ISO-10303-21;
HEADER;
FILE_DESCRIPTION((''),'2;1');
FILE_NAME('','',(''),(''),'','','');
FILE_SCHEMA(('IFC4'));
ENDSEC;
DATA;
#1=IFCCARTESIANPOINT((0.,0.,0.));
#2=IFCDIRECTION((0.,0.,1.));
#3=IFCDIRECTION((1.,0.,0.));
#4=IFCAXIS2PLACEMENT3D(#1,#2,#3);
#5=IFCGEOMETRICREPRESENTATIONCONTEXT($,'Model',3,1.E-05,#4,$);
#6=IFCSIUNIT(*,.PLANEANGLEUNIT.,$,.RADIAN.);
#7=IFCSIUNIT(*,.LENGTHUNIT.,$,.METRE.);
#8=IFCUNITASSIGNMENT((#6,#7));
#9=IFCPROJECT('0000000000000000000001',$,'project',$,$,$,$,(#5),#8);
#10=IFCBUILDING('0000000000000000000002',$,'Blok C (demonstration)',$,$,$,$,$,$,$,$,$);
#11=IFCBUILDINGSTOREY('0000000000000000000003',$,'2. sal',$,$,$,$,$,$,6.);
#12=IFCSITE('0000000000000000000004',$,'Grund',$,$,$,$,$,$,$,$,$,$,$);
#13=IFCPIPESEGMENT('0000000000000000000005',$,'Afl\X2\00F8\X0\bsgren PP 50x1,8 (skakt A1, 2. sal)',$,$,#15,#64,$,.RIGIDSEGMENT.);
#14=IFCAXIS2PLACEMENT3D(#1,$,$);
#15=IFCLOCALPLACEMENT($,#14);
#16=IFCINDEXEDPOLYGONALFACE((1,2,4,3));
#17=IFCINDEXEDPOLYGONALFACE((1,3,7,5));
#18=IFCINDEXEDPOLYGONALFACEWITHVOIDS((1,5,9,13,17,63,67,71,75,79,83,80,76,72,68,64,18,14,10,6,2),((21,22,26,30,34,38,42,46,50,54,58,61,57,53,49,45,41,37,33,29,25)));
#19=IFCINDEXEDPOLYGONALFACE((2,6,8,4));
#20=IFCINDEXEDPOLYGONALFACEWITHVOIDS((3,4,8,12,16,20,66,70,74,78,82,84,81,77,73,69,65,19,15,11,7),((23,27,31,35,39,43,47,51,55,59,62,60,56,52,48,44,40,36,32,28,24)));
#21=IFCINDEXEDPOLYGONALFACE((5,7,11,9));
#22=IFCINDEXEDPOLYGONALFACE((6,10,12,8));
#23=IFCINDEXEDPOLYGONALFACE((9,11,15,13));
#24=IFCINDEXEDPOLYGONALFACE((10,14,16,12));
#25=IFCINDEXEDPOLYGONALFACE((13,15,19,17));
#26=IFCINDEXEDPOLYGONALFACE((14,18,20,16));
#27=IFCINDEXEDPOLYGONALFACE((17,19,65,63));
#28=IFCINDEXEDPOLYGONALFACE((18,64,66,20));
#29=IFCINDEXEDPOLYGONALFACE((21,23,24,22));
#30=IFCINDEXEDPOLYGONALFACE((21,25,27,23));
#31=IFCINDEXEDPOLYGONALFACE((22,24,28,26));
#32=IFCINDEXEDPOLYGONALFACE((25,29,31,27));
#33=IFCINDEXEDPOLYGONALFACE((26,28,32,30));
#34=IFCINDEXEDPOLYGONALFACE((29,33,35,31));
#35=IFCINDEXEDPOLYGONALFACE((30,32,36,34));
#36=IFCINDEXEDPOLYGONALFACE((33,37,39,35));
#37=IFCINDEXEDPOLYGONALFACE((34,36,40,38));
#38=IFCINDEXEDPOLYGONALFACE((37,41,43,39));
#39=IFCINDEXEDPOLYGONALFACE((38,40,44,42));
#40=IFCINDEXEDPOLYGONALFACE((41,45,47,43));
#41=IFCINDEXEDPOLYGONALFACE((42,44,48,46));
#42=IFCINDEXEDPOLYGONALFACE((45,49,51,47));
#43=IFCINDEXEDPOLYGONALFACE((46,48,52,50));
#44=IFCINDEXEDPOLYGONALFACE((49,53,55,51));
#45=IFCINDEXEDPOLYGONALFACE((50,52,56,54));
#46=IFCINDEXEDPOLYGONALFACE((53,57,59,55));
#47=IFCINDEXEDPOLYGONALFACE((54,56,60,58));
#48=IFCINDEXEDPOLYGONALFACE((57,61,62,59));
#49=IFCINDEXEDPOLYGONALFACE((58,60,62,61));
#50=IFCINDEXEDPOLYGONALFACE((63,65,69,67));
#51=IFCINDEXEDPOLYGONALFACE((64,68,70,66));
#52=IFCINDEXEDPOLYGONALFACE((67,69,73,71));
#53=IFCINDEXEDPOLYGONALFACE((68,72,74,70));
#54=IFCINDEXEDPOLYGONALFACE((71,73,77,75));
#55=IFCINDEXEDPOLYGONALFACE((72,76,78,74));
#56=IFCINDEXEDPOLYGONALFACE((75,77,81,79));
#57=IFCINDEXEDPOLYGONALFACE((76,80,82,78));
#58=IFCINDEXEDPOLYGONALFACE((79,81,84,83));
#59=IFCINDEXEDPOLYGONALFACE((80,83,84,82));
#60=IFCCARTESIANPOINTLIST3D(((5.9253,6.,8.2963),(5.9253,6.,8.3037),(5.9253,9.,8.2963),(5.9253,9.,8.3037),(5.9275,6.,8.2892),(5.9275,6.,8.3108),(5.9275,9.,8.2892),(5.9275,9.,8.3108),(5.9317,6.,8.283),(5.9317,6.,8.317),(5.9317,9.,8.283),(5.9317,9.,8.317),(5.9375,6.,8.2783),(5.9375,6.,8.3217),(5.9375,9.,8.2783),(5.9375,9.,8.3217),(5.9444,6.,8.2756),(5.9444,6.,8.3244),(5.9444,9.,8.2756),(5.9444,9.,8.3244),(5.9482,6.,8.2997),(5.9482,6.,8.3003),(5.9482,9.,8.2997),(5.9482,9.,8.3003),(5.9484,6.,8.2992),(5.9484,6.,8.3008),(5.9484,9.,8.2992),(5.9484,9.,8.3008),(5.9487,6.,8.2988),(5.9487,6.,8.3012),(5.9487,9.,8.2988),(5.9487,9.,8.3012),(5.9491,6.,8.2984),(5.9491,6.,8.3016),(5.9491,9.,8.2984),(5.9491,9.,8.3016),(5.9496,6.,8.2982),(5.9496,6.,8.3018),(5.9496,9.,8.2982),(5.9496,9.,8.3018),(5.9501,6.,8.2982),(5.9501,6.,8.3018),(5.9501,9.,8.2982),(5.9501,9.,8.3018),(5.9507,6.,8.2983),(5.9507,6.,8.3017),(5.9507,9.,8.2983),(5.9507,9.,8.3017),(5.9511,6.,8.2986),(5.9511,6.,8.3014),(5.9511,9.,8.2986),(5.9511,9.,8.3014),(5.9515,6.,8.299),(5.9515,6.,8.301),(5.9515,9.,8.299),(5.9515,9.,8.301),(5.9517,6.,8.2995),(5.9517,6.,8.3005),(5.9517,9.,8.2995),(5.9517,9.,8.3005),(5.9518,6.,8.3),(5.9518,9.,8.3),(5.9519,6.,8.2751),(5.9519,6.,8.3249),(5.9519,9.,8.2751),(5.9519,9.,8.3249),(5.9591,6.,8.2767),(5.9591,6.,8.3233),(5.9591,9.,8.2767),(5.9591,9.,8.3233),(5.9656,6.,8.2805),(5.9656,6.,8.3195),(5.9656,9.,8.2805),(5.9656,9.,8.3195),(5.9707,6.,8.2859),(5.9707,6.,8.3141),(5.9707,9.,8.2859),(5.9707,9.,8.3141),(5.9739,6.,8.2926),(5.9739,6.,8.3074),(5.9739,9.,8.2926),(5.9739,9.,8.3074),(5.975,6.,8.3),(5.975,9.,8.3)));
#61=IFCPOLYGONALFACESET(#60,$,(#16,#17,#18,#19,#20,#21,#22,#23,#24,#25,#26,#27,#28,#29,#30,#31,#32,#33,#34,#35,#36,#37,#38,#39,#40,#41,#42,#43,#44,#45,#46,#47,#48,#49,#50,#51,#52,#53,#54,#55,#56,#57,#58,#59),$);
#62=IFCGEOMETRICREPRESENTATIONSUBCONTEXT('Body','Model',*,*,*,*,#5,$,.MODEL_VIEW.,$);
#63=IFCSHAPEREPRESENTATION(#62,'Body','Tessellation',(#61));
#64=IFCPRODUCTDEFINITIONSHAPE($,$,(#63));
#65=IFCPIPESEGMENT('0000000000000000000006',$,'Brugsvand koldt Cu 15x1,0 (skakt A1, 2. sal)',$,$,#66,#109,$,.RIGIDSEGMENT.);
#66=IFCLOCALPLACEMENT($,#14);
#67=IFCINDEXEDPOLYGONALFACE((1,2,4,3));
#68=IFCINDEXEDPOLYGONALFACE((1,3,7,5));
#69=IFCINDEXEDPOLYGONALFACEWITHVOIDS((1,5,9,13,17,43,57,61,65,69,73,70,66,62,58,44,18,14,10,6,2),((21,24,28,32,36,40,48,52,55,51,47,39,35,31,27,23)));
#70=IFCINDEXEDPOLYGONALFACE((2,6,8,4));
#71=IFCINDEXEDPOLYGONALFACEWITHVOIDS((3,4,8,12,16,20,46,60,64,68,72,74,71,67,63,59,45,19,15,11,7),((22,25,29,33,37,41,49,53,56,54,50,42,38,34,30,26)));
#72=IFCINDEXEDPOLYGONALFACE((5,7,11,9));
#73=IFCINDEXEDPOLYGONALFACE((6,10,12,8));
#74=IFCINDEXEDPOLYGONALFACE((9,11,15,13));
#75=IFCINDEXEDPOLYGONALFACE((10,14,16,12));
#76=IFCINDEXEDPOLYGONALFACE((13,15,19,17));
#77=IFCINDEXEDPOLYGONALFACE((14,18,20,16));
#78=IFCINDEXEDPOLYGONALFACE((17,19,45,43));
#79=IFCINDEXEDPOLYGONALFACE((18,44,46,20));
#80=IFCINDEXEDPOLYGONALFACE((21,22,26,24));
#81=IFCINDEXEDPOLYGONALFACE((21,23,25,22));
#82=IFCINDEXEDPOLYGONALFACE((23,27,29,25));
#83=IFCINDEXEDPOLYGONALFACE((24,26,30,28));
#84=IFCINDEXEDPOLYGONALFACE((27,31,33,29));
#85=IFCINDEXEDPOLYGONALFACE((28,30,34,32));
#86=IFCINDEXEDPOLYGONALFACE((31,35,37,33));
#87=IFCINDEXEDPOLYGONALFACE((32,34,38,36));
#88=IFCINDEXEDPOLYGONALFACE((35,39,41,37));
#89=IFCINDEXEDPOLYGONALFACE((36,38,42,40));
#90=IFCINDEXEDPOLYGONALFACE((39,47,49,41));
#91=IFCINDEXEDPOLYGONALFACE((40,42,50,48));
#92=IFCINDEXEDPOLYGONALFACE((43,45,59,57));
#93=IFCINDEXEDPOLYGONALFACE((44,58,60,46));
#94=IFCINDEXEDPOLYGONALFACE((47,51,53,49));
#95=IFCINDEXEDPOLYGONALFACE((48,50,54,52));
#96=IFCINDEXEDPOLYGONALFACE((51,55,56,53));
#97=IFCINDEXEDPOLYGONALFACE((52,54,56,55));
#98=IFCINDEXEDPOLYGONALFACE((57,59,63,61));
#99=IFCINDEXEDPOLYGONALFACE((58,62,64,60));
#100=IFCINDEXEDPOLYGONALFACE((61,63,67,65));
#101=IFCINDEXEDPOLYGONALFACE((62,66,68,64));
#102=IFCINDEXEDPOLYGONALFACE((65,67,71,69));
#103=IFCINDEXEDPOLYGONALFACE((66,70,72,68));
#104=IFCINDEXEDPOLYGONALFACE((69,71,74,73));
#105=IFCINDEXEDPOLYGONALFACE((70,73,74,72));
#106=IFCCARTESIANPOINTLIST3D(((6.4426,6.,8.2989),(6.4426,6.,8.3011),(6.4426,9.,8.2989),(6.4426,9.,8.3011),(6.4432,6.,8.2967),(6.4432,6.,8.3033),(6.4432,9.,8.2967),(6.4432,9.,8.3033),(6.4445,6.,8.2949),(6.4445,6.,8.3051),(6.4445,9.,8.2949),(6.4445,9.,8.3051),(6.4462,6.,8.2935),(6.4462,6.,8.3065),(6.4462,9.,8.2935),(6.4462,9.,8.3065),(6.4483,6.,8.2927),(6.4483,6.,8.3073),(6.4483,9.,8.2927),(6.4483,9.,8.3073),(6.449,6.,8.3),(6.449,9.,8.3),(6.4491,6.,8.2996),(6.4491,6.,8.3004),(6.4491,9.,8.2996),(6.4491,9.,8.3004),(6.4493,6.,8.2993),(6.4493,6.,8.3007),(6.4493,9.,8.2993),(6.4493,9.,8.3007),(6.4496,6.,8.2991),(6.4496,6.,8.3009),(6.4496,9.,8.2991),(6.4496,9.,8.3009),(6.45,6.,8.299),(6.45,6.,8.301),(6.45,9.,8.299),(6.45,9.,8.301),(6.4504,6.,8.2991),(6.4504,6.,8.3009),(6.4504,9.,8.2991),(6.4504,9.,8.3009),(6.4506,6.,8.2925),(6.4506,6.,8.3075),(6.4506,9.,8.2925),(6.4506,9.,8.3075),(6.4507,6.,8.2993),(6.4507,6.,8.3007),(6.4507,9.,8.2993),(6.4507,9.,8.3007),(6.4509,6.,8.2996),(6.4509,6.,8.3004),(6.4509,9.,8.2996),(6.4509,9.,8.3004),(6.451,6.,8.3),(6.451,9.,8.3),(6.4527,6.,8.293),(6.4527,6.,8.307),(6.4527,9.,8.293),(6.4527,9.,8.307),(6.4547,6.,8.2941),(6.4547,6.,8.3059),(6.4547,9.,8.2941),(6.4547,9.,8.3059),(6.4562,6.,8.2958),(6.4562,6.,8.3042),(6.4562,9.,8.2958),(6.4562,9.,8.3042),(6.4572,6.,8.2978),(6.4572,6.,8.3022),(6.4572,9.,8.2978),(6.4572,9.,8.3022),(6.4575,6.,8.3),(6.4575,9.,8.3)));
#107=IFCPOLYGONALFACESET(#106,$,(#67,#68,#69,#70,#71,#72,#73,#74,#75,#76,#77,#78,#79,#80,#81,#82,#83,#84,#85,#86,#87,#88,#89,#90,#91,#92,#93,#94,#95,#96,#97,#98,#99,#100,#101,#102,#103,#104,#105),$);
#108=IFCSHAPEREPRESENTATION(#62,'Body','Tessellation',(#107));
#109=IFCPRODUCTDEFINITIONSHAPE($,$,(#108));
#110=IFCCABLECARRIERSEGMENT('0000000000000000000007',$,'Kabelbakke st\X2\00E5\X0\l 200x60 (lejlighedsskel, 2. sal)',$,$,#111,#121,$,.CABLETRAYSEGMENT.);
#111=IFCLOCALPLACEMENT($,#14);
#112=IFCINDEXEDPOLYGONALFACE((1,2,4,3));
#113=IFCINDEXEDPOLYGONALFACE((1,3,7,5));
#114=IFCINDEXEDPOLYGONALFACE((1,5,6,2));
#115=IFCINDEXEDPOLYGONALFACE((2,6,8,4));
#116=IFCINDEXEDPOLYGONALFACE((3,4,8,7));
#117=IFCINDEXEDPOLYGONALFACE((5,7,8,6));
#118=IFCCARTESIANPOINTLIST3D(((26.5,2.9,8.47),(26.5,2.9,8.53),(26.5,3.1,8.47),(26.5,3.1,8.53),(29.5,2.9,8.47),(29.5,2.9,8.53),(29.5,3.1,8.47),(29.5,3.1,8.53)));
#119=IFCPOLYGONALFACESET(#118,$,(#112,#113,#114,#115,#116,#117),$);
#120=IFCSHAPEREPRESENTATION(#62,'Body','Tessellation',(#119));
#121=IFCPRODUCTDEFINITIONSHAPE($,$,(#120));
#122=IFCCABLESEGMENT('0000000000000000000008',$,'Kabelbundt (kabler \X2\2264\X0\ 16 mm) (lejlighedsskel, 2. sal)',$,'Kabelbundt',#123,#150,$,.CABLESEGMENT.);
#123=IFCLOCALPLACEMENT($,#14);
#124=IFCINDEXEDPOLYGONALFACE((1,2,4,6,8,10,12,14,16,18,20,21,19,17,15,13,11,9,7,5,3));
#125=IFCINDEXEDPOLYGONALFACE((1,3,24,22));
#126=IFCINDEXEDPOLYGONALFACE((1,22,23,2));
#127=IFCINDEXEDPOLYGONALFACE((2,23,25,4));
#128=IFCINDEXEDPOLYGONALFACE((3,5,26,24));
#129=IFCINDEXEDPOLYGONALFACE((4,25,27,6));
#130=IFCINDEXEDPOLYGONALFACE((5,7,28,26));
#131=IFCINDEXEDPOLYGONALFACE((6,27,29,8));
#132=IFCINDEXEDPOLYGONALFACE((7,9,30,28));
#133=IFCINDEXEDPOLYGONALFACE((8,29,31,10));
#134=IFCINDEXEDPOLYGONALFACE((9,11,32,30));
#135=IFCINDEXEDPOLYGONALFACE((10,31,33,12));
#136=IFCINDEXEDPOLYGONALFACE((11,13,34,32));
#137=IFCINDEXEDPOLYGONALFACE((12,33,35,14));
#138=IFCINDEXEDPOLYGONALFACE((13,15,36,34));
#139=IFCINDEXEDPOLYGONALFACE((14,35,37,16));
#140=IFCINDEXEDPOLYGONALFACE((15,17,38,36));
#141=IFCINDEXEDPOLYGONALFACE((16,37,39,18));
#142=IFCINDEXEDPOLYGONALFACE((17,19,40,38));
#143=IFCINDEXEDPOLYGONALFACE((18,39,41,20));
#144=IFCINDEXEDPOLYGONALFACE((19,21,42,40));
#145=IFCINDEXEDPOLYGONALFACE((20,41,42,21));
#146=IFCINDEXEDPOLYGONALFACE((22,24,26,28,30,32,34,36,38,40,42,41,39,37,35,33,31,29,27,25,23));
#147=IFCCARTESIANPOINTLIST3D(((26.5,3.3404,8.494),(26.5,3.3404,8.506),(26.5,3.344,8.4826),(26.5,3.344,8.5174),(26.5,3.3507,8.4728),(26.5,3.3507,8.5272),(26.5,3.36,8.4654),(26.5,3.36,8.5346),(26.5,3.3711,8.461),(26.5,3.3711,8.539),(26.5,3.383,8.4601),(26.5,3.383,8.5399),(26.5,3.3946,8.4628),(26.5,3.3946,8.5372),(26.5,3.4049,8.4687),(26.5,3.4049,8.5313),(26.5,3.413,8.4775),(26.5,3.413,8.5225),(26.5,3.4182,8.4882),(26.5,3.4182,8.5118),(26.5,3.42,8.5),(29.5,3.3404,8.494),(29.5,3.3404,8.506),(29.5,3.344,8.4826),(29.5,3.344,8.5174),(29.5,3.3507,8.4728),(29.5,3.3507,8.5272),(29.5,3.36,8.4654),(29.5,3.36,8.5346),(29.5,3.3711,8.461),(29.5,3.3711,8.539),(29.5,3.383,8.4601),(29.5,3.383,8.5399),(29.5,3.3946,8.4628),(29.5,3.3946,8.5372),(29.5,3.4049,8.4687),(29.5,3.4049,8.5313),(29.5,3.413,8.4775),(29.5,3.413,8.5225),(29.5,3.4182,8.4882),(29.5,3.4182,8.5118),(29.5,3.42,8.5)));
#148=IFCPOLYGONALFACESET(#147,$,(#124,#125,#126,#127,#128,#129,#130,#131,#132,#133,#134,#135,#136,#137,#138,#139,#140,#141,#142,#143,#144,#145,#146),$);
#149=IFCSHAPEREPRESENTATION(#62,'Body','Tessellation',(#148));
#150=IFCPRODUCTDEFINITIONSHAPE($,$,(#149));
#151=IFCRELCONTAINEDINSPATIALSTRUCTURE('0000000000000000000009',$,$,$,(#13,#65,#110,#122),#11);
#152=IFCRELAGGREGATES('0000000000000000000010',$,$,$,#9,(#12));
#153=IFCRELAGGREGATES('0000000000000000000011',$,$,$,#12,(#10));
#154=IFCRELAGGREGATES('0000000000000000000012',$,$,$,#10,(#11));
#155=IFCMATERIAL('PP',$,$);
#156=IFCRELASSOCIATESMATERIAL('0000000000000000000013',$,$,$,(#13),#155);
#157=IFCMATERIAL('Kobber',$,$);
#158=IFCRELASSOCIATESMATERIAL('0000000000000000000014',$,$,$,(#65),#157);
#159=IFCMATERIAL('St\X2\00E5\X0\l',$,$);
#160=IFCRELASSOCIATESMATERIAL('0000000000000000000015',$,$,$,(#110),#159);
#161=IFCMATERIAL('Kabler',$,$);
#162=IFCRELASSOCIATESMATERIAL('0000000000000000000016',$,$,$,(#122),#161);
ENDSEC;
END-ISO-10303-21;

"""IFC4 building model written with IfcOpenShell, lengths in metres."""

from ifc_helpers import new_model, si_unit, frame, origin_with_axes, place, context, subcontext, project, spatial, polyline, circle, hollow_circle, outline, extrude, material, element, save


model = new_model("IFC4")

# Units and contexts
model_context = context("Model", 3, precision=1e-05, world=origin_with_axes())
body_context = subcontext(model_context, "Body", "Model", "MODEL_VIEW")
ifc_project = project(units=[si_unit("PLANEANGLEUNIT", "RADIAN"), si_unit("LENGTHUNIT", "METRE")], contexts=[model_context])

# Site, building, storey
site = spatial("IfcSite", under=ifc_project, Name="Grund")
building = spatial("IfcBuilding", under=site, Name="Blok C (demonstration)")
storey = spatial("IfcBuildingStorey", under=building, Name="2. sal", Elevation=6.0)

# Pipe segments
ifc_material_1 = material(Name="PP")
pipe_segment_1_placement = place(None, origin_with_axes())
element("IfcPipeSegment", 1, at=pipe_segment_1_placement, inside=storey, material=ifc_material_1, Name="Afløbsgren PP 50x1,8 (skakt A1, 2. sal)", PredefinedType="RIGIDSEGMENT", context=body_context, shape_type="SweptSolid", body=[
    extrude(hollow_circle(Radius=0.025, WallThickness=0.0232), frame((5.95, 6.0, 8.3), z_axis=(0.0, 1.0, 0.0), x_axis=(1.0, 0.0, 0.0)), (0.0, 0.0, 1.0), 3.0),
])
ifc_material_2 = material(Name="Kobber")
pipe_segment_2_placement = place(None, origin_with_axes())
element("IfcPipeSegment", 2, at=pipe_segment_2_placement, inside=storey, material=ifc_material_2, Name="Brugsvand koldt Cu 15x1,0 (skakt A1, 2. sal)", PredefinedType="RIGIDSEGMENT", context=body_context, shape_type="SweptSolid", body=[
    extrude(hollow_circle(Radius=0.0075, WallThickness=0.0065), frame((6.45, 6.0, 8.3), z_axis=(0.0, 1.0, 0.0), x_axis=(1.0, 0.0, 0.0)), (0.0, 0.0, 1.0), 3.0),
])

# Cable carrier segment
ifc_material_3 = material(Name="Stål")
cable_carrier_segment_placement = place(None, origin_with_axes())
element("IfcCableCarrierSegment", 3, at=cable_carrier_segment_placement, inside=storey, material=ifc_material_3, Name="Kabelbakke stål 200x60 (lejlighedsskel, 2. sal)", PredefinedType="CABLETRAYSEGMENT", context=body_context, shape_type="SweptSolid", body=[
    extrude(outline(polyline([(26.5, 2.9), (29.5, 2.9), (29.5, 3.1), (26.5, 3.1), (26.5, 2.9)])), frame((0.0, 0.0, 8.47)), (0.0, 0.0, 1.0), 0.06),
])

# Cable segment
ifc_material_4 = material(Name="Kabler")
cable_segment_placement = place(None, origin_with_axes())
element("IfcCableSegment", 4, at=cable_segment_placement, inside=storey, material=ifc_material_4, Name="Kabelbundt (kabler ≤ 16 mm) (lejlighedsskel, 2. sal)", ObjectType="Kabelbundt", PredefinedType="CABLESEGMENT", context=body_context, shape_type="SweptSolid", body=[
    extrude(circle(Radius=0.04), frame((26.5, 3.38, 8.5), z_axis=(1.0, 0.0, 0.0), x_axis=(0.0, 1.0, 0.0)), (0.0, 0.0, 1.0), 3.0),
])

save(model, "model.ifc")
